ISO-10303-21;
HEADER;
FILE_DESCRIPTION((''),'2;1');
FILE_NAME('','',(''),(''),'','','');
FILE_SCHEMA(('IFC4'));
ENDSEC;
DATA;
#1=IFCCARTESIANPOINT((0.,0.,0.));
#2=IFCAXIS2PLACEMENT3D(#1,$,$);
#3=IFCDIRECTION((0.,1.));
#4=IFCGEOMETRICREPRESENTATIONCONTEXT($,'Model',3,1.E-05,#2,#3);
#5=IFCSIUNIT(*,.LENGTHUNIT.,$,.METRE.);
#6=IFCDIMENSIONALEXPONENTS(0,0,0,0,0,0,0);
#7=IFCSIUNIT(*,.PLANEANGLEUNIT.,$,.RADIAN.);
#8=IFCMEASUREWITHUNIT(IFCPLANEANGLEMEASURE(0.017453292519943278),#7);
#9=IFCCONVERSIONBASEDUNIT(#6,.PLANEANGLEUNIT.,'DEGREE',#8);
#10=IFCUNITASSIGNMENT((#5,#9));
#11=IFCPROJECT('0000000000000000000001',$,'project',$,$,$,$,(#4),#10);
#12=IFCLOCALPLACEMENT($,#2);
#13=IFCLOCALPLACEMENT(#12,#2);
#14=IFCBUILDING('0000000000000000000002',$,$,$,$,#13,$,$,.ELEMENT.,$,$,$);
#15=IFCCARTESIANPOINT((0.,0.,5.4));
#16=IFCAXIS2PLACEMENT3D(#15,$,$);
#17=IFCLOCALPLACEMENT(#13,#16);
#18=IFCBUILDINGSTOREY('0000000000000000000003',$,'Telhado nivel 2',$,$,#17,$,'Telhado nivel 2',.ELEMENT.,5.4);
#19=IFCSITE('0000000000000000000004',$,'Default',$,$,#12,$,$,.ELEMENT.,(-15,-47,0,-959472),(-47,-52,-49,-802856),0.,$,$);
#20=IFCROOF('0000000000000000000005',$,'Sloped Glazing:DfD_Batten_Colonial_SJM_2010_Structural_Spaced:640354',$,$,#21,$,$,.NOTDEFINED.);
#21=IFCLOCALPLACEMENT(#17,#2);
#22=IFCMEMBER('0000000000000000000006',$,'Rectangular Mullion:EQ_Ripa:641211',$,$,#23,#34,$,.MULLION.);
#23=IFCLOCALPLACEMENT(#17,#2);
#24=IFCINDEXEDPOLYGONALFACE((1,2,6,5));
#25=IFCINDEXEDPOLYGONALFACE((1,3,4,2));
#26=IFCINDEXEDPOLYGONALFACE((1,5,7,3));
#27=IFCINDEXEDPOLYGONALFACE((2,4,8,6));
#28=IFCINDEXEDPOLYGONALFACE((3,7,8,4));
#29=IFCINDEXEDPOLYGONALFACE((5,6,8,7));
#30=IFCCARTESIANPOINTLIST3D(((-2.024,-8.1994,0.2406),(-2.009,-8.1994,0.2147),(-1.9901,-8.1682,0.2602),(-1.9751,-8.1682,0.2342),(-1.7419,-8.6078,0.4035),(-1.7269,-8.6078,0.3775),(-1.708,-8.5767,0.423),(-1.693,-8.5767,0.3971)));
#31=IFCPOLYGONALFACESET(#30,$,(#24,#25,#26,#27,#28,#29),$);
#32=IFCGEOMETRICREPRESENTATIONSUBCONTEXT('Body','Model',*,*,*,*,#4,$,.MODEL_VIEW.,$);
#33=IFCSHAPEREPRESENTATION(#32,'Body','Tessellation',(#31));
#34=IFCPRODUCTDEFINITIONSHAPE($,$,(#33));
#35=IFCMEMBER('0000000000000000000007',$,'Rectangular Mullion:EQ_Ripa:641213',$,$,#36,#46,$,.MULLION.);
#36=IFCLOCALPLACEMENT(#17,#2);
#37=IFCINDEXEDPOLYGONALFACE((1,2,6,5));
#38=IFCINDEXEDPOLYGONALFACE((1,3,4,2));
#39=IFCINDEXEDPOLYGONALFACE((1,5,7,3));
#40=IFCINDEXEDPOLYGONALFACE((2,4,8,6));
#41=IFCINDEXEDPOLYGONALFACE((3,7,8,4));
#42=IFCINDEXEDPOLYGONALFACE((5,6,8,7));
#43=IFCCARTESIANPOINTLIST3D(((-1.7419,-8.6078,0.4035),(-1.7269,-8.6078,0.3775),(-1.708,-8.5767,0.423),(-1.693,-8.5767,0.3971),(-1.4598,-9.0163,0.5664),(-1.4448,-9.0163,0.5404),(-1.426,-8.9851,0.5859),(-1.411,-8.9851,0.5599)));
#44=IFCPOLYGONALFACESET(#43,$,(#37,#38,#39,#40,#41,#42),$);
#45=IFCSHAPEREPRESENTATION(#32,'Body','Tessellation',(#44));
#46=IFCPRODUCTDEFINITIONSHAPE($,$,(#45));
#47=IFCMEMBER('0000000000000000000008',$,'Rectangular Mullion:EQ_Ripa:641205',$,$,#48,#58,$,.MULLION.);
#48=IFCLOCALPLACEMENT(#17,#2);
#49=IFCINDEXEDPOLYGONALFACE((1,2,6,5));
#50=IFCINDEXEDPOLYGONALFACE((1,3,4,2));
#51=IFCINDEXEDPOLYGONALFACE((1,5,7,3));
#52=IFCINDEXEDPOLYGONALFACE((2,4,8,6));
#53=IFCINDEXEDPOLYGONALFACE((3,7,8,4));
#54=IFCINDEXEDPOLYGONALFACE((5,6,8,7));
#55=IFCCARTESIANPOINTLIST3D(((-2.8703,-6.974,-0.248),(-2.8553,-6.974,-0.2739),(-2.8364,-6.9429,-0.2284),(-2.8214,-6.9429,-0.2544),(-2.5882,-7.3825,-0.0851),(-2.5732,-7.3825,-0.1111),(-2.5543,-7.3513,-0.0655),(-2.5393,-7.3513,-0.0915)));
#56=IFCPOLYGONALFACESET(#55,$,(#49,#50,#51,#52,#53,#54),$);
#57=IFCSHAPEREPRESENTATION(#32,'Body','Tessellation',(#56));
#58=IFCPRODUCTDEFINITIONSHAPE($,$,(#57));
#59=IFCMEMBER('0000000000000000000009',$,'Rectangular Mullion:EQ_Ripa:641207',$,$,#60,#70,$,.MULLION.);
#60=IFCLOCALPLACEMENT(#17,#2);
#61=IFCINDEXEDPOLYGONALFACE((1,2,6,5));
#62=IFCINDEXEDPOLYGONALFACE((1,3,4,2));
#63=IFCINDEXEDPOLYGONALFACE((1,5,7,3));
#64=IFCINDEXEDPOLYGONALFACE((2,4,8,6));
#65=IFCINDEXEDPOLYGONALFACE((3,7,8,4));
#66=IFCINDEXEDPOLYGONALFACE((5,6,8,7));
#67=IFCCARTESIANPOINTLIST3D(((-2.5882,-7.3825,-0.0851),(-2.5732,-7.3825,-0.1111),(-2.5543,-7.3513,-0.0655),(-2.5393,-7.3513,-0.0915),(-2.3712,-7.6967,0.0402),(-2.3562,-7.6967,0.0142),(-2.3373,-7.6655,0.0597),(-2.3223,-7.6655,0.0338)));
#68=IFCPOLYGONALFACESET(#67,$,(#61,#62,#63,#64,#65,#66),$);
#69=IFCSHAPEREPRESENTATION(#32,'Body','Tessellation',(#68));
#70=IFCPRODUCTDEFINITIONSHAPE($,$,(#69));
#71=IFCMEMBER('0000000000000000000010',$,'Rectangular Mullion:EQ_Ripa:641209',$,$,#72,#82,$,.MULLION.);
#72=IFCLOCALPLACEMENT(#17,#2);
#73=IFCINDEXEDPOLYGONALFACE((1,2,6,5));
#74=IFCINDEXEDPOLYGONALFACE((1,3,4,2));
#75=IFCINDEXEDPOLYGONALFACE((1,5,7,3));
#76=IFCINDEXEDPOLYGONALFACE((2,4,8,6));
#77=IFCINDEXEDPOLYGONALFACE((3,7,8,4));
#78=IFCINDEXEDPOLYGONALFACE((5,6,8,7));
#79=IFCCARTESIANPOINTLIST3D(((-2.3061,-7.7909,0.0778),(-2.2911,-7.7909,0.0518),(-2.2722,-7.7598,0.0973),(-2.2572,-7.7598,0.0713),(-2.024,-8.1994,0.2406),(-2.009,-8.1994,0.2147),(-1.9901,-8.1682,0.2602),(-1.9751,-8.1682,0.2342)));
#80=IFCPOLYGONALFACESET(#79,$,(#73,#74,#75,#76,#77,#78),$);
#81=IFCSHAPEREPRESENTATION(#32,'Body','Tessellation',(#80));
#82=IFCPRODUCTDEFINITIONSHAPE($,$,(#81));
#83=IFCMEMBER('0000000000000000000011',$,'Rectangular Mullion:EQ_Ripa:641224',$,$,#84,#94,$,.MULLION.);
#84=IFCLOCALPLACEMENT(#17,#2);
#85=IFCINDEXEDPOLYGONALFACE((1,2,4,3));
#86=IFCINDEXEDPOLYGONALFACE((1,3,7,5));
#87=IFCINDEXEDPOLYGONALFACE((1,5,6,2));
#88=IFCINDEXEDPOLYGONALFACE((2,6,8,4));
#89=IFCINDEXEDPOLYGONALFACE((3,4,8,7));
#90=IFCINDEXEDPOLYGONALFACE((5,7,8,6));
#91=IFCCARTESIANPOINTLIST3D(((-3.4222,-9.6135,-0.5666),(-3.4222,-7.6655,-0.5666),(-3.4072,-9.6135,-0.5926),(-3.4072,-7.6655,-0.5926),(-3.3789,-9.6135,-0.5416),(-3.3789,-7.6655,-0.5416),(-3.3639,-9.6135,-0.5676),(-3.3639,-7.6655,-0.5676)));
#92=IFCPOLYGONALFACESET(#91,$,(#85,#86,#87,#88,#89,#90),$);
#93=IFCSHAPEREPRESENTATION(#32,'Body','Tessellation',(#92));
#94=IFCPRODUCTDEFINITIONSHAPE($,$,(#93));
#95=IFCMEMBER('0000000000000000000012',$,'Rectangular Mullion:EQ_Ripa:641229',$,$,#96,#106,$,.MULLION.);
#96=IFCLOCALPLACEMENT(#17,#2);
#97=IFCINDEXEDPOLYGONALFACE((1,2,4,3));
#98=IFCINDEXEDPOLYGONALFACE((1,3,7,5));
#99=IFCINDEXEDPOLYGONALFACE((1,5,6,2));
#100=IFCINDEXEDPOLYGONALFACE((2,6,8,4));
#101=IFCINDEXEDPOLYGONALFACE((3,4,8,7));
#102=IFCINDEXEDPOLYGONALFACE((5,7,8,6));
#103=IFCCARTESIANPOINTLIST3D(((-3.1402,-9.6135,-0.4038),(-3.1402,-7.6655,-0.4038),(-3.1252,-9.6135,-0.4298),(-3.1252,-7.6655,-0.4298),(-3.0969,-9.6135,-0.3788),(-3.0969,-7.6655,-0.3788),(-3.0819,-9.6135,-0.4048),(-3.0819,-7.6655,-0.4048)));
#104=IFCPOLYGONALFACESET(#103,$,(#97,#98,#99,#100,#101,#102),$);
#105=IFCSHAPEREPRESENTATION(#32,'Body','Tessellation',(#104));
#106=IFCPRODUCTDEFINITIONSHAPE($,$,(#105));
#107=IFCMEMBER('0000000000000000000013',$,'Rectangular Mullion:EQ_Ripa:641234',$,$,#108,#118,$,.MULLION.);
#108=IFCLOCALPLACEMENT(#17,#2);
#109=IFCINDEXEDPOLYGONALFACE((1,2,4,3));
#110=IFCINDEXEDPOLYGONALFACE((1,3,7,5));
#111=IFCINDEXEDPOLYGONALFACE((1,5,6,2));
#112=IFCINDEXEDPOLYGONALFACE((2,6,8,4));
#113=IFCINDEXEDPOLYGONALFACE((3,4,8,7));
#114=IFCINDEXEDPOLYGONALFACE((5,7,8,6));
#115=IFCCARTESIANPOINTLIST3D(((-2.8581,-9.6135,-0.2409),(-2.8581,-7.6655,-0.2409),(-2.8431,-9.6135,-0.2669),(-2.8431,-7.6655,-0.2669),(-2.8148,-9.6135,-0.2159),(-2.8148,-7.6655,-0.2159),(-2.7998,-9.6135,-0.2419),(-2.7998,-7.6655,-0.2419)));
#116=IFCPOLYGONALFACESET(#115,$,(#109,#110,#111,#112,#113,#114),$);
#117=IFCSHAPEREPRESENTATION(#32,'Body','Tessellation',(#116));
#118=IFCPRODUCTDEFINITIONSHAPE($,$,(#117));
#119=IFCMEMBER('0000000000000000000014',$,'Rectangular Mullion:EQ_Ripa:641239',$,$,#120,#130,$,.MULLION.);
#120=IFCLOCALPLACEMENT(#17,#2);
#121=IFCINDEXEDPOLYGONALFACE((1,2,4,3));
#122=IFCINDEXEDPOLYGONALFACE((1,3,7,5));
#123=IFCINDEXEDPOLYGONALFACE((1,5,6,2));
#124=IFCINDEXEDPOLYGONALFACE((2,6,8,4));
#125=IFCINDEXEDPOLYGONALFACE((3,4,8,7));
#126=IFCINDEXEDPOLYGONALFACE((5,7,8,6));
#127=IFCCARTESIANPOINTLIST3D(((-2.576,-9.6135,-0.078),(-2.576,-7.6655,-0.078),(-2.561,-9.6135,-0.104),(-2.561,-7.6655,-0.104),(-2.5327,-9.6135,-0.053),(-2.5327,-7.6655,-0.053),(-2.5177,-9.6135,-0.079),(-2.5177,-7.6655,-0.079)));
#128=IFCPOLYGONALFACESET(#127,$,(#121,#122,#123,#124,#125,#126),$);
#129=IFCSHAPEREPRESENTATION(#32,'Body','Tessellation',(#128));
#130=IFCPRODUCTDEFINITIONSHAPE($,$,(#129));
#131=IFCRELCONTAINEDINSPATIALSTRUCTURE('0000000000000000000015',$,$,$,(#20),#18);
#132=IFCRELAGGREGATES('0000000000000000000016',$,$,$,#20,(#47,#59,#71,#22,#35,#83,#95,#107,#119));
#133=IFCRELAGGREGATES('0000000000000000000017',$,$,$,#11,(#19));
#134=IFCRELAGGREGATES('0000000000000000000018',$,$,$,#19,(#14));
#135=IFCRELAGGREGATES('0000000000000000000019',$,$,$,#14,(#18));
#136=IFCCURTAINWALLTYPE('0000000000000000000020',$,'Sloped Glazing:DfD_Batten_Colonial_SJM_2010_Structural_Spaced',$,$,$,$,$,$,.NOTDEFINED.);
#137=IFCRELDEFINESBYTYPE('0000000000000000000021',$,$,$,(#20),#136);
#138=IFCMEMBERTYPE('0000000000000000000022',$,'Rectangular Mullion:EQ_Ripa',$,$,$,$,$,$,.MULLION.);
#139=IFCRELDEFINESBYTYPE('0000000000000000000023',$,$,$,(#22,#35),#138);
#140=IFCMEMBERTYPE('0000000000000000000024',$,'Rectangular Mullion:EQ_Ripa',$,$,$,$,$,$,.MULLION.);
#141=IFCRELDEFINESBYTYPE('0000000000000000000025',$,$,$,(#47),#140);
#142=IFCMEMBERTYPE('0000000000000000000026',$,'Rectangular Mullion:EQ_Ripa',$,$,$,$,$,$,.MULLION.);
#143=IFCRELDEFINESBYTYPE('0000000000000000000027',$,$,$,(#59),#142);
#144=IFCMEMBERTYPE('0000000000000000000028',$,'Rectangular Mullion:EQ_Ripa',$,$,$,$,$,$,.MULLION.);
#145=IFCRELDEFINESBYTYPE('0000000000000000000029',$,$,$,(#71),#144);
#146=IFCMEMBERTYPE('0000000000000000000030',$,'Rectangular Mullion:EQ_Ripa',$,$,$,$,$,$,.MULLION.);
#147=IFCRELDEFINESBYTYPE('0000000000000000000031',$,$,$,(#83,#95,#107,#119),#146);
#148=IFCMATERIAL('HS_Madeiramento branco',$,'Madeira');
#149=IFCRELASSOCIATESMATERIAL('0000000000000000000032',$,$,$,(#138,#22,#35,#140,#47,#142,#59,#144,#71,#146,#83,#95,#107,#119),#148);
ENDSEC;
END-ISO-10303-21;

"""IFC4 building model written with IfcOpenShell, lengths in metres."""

from ifc_helpers import new_model, entity, si_unit, converted_unit, direction, frame, origin, place, context, subcontext, project, spatial, indexed_curve, outline, extrude, source, transform, mapped, material, type_object, type_shapes, element, aggregate, save


model = new_model("IFC4")

# Units and contexts
model_context = context("Model", 3, precision=1e-05, world=origin(), true_north=direction((0.0, 1.0)))
body_context = subcontext(model_context, "Body", "Model", "MODEL_VIEW")
ifc_project = project(units=[si_unit("LENGTHUNIT", "METRE"), converted_unit("PLANEANGLEUNIT", "DEGREE", entity("IfcPlaneAngleMeasure", 0.017453292519943278), si_unit("PLANEANGLEUNIT", "RADIAN"), dimensions=[0, 0, 0, 0, 0, 0, 0])], contexts=[model_context])

# Site, building, storey
site_placement = place(None, origin())
site = spatial("IfcSite", under=ifc_project, at=site_placement, Name="Default", CompositionType="ELEMENT", RefLatitude=(-15, -47, 0, -959472), RefLongitude=(-47, -52, -49, -802856), RefElevation=0.0)
building_placement = place(site_placement, origin())
building = spatial("IfcBuilding", under=site, at=building_placement, CompositionType="ELEMENT")
storey_placement = place(building_placement, frame((0.0, 0.0, 5.4)))
storey = spatial("IfcBuildingStorey", under=building, at=storey_placement, Name="Telhado nivel 2", LongName="Telhado nivel 2", CompositionType="ELEMENT", Elevation=5.4)

# Roof, members
curtain_wall_type = type_object("IfcCurtainWallType", Name="Sloped Glazing:DfD_Batten_Colonial_SJM_2010_Structural_Spaced", PredefinedType="NOTDEFINED")
roof_placement = place(storey_placement, frame((0.0, 0.0, -5.4)))
roof = element("IfcRoof", 1, at=roof_placement, inside=storey, type_object=curtain_wall_type, Name="Sloped Glazing:DfD_Batten_Colonial_SJM_2010_Structural_Spaced:640354", PredefinedType="NOTDEFINED")
ifc_material = material(Name="HS_Madeiramento branco", Category="Madeira")
member_type_1 = type_object("IfcMemberType", Name="Rectangular Mullion:EQ_Ripa", PredefinedType="MULLION", material=ifc_material)
shared_shape_1 = source(origin(), body_context, "Body", "SweptSolid", [
    extrude(outline(indexed_curve([(-0.025, -0.015), (0.025, -0.015), (0.025, 0.015), (-0.025, 0.015), (-0.025, -0.015)], self_intersect=False)), frame((-0.025, 0.0, -0.5224), z_axis=(0.0, 0.0, 1.0), x_axis=(-1.0, 0.0, 0.0)), (0.0, 0.0, 1.0), 0.5224),
])
type_shapes(member_type_1, [shared_shape_1])
member_1_placement = place(roof_placement, frame((-1.9826, -8.1682, 5.6472), z_axis=(-0.539965, 0.781825, -0.311749), x_axis=(0.67708, 0.623498, 0.390913)))
member_1 = element("IfcMember", 2, at=member_1_placement, type_object=member_type_1, material=ifc_material, Name="Rectangular Mullion:EQ_Ripa:641211", PredefinedType="MULLION", context=body_context, shape_type="MappedRepresentation", body=[
    mapped(shared_shape_1, transform((0.0, 0.0, 0.0), scale=1.0)),
])
member_2_placement = place(roof_placement, frame((-1.7005, -8.5767, 5.8101), z_axis=(-0.539965, 0.781825, -0.311749), x_axis=(0.67708, 0.623498, 0.390913)))
member_2 = element("IfcMember", 3, at=member_2_placement, type_object=member_type_1, material=ifc_material, Name="Rectangular Mullion:EQ_Ripa:641213", PredefinedType="MULLION", context=body_context, shape_type="MappedRepresentation", body=[
    mapped(shared_shape_1, transform((0.0, 0.0, 0.0), scale=1.0)),
])
member_type_2 = type_object("IfcMemberType", Name="Rectangular Mullion:EQ_Ripa", PredefinedType="MULLION", material=ifc_material)
shared_shape_2 = source(origin(), body_context, "Body", "SweptSolid", [
    extrude(outline(indexed_curve([(-0.025, -0.015), (0.025, -0.015), (0.025, 0.015), (-0.025, 0.015), (-0.025, -0.015)], self_intersect=False)), frame((-0.025, 0.0, -0.5224), z_axis=(0.0, 0.0, 1.0), x_axis=(-1.0, 0.0, 0.0)), (0.0, 0.0, 1.0), 0.5224),
])
type_shapes(member_type_2, [shared_shape_2])
member_3_placement = place(roof_placement, frame((-2.8289, -6.9429, 5.1586), z_axis=(-0.539965, 0.781825, -0.311749), x_axis=(0.67708, 0.623498, 0.390913)))
member_3 = element("IfcMember", 4, at=member_3_placement, type_object=member_type_2, material=ifc_material, Name="Rectangular Mullion:EQ_Ripa:641205", PredefinedType="MULLION", context=body_context, shape_type="MappedRepresentation", body=[
    mapped(shared_shape_2, transform((0.0, 0.0, 0.0), scale=1.0)),
])
member_type_3 = type_object("IfcMemberType", Name="Rectangular Mullion:EQ_Ripa", PredefinedType="MULLION", material=ifc_material)
shared_shape_3 = source(origin(), body_context, "Body", "SweptSolid", [
    extrude(outline(indexed_curve([(-0.025, -0.015), (0.025, -0.015), (0.025, 0.015), (-0.025, 0.015), (-0.025, -0.015)], self_intersect=False)), frame((-0.025, 0.0, -0.4019), z_axis=(0.0, 0.0, 1.0), x_axis=(-1.0, 0.0, 0.0)), (0.0, 0.0, 1.0), 0.4019),
])
type_shapes(member_type_3, [shared_shape_3])
member_4_placement = place(roof_placement, frame((-2.5468, -7.3513, 5.3215), z_axis=(-0.539965, 0.781825, -0.311749), x_axis=(0.67708, 0.623498, 0.390913)))
member_4 = element("IfcMember", 5, at=member_4_placement, type_object=member_type_3, material=ifc_material, Name="Rectangular Mullion:EQ_Ripa:641207", PredefinedType="MULLION", context=body_context, shape_type="MappedRepresentation", body=[
    mapped(shared_shape_3, transform((0.0, 0.0, 0.0), scale=1.0)),
])
member_type_4 = type_object("IfcMemberType", Name="Rectangular Mullion:EQ_Ripa", PredefinedType="MULLION", material=ifc_material)
shared_shape_4 = source(origin(), body_context, "Body", "SweptSolid", [
    extrude(outline(indexed_curve([(-0.025, -0.015), (0.025, -0.015), (0.025, 0.015), (-0.025, 0.015), (-0.025, -0.015)], self_intersect=False)), frame((-0.025, 0.0, -0.5224), z_axis=(0.0, 0.0, 1.0), x_axis=(-1.0, 0.0, 0.0)), (0.0, 0.0, 1.0), 0.5224),
])
type_shapes(member_type_4, [shared_shape_4])
member_5_placement = place(roof_placement, frame((-2.2647, -7.7598, 5.4843), z_axis=(-0.539965, 0.781825, -0.311749), x_axis=(0.67708, 0.623498, 0.390913)))
member_5 = element("IfcMember", 6, at=member_5_placement, type_object=member_type_4, material=ifc_material, Name="Rectangular Mullion:EQ_Ripa:641209", PredefinedType="MULLION", context=body_context, shape_type="MappedRepresentation", body=[
    mapped(shared_shape_4, transform((0.0, 0.0, 0.0), scale=1.0)),
])
member_type_5 = type_object("IfcMemberType", Name="Rectangular Mullion:EQ_Ripa", PredefinedType="MULLION", material=ifc_material)
shared_shape_5 = source(origin(), body_context, "Body", "SweptSolid", [
    extrude(outline(indexed_curve([(-0.025, -0.015), (0.025, -0.015), (0.025, 0.015), (-0.025, 0.015), (-0.025, -0.015)], self_intersect=False)), frame((0.0, 0.0, -1.948), z_axis=(0.0, 0.0, 1.0), x_axis=(-1.0, 0.0, 0.0)), (0.0, 0.0, 1.0), 1.948),
])
type_shapes(member_type_5, [shared_shape_5])
member_6_placement = place(roof_placement, frame((-3.3931, -7.6655, 4.8329), z_axis=(0.0, 1.0, 0.0), x_axis=(0.866025, 0.0, 0.5)))
member_6 = element("IfcMember", 7, at=member_6_placement, type_object=member_type_5, material=ifc_material, Name="Rectangular Mullion:EQ_Ripa:641224", PredefinedType="MULLION", context=body_context, shape_type="MappedRepresentation", body=[
    mapped(shared_shape_5, transform((0.0, 0.0, 0.0), scale=1.0)),
])
member_7_placement = place(roof_placement, frame((-3.111, -7.6655, 4.9957), z_axis=(0.0, 1.0, 0.0), x_axis=(0.866025, 0.0, 0.5)))
member_7 = element("IfcMember", 8, at=member_7_placement, type_object=member_type_5, material=ifc_material, Name="Rectangular Mullion:EQ_Ripa:641229", PredefinedType="MULLION", context=body_context, shape_type="MappedRepresentation", body=[
    mapped(shared_shape_5, transform((0.0, 0.0, 0.0), scale=1.0)),
])
member_8_placement = place(roof_placement, frame((-2.8289, -7.6655, 5.1586), z_axis=(0.0, 1.0, 0.0), x_axis=(0.866025, 0.0, 0.5)))
member_8 = element("IfcMember", 9, at=member_8_placement, type_object=member_type_5, material=ifc_material, Name="Rectangular Mullion:EQ_Ripa:641234", PredefinedType="MULLION", context=body_context, shape_type="MappedRepresentation", body=[
    mapped(shared_shape_5, transform((0.0, 0.0, 0.0), scale=1.0)),
])
member_9_placement = place(roof_placement, frame((-2.5468, -7.6655, 5.3215), z_axis=(0.0, 1.0, 0.0), x_axis=(0.866025, 0.0, 0.5)))
member_9 = element("IfcMember", 10, at=member_9_placement, type_object=member_type_5, material=ifc_material, Name="Rectangular Mullion:EQ_Ripa:641239", PredefinedType="MULLION", context=body_context, shape_type="MappedRepresentation", body=[
    mapped(shared_shape_5, transform((0.0, 0.0, 0.0), scale=1.0)),
])
aggregate(roof, [member_3, member_4, member_5, member_1, member_2, member_6, member_7, member_8, member_9])

save(model, "model.ifc")
